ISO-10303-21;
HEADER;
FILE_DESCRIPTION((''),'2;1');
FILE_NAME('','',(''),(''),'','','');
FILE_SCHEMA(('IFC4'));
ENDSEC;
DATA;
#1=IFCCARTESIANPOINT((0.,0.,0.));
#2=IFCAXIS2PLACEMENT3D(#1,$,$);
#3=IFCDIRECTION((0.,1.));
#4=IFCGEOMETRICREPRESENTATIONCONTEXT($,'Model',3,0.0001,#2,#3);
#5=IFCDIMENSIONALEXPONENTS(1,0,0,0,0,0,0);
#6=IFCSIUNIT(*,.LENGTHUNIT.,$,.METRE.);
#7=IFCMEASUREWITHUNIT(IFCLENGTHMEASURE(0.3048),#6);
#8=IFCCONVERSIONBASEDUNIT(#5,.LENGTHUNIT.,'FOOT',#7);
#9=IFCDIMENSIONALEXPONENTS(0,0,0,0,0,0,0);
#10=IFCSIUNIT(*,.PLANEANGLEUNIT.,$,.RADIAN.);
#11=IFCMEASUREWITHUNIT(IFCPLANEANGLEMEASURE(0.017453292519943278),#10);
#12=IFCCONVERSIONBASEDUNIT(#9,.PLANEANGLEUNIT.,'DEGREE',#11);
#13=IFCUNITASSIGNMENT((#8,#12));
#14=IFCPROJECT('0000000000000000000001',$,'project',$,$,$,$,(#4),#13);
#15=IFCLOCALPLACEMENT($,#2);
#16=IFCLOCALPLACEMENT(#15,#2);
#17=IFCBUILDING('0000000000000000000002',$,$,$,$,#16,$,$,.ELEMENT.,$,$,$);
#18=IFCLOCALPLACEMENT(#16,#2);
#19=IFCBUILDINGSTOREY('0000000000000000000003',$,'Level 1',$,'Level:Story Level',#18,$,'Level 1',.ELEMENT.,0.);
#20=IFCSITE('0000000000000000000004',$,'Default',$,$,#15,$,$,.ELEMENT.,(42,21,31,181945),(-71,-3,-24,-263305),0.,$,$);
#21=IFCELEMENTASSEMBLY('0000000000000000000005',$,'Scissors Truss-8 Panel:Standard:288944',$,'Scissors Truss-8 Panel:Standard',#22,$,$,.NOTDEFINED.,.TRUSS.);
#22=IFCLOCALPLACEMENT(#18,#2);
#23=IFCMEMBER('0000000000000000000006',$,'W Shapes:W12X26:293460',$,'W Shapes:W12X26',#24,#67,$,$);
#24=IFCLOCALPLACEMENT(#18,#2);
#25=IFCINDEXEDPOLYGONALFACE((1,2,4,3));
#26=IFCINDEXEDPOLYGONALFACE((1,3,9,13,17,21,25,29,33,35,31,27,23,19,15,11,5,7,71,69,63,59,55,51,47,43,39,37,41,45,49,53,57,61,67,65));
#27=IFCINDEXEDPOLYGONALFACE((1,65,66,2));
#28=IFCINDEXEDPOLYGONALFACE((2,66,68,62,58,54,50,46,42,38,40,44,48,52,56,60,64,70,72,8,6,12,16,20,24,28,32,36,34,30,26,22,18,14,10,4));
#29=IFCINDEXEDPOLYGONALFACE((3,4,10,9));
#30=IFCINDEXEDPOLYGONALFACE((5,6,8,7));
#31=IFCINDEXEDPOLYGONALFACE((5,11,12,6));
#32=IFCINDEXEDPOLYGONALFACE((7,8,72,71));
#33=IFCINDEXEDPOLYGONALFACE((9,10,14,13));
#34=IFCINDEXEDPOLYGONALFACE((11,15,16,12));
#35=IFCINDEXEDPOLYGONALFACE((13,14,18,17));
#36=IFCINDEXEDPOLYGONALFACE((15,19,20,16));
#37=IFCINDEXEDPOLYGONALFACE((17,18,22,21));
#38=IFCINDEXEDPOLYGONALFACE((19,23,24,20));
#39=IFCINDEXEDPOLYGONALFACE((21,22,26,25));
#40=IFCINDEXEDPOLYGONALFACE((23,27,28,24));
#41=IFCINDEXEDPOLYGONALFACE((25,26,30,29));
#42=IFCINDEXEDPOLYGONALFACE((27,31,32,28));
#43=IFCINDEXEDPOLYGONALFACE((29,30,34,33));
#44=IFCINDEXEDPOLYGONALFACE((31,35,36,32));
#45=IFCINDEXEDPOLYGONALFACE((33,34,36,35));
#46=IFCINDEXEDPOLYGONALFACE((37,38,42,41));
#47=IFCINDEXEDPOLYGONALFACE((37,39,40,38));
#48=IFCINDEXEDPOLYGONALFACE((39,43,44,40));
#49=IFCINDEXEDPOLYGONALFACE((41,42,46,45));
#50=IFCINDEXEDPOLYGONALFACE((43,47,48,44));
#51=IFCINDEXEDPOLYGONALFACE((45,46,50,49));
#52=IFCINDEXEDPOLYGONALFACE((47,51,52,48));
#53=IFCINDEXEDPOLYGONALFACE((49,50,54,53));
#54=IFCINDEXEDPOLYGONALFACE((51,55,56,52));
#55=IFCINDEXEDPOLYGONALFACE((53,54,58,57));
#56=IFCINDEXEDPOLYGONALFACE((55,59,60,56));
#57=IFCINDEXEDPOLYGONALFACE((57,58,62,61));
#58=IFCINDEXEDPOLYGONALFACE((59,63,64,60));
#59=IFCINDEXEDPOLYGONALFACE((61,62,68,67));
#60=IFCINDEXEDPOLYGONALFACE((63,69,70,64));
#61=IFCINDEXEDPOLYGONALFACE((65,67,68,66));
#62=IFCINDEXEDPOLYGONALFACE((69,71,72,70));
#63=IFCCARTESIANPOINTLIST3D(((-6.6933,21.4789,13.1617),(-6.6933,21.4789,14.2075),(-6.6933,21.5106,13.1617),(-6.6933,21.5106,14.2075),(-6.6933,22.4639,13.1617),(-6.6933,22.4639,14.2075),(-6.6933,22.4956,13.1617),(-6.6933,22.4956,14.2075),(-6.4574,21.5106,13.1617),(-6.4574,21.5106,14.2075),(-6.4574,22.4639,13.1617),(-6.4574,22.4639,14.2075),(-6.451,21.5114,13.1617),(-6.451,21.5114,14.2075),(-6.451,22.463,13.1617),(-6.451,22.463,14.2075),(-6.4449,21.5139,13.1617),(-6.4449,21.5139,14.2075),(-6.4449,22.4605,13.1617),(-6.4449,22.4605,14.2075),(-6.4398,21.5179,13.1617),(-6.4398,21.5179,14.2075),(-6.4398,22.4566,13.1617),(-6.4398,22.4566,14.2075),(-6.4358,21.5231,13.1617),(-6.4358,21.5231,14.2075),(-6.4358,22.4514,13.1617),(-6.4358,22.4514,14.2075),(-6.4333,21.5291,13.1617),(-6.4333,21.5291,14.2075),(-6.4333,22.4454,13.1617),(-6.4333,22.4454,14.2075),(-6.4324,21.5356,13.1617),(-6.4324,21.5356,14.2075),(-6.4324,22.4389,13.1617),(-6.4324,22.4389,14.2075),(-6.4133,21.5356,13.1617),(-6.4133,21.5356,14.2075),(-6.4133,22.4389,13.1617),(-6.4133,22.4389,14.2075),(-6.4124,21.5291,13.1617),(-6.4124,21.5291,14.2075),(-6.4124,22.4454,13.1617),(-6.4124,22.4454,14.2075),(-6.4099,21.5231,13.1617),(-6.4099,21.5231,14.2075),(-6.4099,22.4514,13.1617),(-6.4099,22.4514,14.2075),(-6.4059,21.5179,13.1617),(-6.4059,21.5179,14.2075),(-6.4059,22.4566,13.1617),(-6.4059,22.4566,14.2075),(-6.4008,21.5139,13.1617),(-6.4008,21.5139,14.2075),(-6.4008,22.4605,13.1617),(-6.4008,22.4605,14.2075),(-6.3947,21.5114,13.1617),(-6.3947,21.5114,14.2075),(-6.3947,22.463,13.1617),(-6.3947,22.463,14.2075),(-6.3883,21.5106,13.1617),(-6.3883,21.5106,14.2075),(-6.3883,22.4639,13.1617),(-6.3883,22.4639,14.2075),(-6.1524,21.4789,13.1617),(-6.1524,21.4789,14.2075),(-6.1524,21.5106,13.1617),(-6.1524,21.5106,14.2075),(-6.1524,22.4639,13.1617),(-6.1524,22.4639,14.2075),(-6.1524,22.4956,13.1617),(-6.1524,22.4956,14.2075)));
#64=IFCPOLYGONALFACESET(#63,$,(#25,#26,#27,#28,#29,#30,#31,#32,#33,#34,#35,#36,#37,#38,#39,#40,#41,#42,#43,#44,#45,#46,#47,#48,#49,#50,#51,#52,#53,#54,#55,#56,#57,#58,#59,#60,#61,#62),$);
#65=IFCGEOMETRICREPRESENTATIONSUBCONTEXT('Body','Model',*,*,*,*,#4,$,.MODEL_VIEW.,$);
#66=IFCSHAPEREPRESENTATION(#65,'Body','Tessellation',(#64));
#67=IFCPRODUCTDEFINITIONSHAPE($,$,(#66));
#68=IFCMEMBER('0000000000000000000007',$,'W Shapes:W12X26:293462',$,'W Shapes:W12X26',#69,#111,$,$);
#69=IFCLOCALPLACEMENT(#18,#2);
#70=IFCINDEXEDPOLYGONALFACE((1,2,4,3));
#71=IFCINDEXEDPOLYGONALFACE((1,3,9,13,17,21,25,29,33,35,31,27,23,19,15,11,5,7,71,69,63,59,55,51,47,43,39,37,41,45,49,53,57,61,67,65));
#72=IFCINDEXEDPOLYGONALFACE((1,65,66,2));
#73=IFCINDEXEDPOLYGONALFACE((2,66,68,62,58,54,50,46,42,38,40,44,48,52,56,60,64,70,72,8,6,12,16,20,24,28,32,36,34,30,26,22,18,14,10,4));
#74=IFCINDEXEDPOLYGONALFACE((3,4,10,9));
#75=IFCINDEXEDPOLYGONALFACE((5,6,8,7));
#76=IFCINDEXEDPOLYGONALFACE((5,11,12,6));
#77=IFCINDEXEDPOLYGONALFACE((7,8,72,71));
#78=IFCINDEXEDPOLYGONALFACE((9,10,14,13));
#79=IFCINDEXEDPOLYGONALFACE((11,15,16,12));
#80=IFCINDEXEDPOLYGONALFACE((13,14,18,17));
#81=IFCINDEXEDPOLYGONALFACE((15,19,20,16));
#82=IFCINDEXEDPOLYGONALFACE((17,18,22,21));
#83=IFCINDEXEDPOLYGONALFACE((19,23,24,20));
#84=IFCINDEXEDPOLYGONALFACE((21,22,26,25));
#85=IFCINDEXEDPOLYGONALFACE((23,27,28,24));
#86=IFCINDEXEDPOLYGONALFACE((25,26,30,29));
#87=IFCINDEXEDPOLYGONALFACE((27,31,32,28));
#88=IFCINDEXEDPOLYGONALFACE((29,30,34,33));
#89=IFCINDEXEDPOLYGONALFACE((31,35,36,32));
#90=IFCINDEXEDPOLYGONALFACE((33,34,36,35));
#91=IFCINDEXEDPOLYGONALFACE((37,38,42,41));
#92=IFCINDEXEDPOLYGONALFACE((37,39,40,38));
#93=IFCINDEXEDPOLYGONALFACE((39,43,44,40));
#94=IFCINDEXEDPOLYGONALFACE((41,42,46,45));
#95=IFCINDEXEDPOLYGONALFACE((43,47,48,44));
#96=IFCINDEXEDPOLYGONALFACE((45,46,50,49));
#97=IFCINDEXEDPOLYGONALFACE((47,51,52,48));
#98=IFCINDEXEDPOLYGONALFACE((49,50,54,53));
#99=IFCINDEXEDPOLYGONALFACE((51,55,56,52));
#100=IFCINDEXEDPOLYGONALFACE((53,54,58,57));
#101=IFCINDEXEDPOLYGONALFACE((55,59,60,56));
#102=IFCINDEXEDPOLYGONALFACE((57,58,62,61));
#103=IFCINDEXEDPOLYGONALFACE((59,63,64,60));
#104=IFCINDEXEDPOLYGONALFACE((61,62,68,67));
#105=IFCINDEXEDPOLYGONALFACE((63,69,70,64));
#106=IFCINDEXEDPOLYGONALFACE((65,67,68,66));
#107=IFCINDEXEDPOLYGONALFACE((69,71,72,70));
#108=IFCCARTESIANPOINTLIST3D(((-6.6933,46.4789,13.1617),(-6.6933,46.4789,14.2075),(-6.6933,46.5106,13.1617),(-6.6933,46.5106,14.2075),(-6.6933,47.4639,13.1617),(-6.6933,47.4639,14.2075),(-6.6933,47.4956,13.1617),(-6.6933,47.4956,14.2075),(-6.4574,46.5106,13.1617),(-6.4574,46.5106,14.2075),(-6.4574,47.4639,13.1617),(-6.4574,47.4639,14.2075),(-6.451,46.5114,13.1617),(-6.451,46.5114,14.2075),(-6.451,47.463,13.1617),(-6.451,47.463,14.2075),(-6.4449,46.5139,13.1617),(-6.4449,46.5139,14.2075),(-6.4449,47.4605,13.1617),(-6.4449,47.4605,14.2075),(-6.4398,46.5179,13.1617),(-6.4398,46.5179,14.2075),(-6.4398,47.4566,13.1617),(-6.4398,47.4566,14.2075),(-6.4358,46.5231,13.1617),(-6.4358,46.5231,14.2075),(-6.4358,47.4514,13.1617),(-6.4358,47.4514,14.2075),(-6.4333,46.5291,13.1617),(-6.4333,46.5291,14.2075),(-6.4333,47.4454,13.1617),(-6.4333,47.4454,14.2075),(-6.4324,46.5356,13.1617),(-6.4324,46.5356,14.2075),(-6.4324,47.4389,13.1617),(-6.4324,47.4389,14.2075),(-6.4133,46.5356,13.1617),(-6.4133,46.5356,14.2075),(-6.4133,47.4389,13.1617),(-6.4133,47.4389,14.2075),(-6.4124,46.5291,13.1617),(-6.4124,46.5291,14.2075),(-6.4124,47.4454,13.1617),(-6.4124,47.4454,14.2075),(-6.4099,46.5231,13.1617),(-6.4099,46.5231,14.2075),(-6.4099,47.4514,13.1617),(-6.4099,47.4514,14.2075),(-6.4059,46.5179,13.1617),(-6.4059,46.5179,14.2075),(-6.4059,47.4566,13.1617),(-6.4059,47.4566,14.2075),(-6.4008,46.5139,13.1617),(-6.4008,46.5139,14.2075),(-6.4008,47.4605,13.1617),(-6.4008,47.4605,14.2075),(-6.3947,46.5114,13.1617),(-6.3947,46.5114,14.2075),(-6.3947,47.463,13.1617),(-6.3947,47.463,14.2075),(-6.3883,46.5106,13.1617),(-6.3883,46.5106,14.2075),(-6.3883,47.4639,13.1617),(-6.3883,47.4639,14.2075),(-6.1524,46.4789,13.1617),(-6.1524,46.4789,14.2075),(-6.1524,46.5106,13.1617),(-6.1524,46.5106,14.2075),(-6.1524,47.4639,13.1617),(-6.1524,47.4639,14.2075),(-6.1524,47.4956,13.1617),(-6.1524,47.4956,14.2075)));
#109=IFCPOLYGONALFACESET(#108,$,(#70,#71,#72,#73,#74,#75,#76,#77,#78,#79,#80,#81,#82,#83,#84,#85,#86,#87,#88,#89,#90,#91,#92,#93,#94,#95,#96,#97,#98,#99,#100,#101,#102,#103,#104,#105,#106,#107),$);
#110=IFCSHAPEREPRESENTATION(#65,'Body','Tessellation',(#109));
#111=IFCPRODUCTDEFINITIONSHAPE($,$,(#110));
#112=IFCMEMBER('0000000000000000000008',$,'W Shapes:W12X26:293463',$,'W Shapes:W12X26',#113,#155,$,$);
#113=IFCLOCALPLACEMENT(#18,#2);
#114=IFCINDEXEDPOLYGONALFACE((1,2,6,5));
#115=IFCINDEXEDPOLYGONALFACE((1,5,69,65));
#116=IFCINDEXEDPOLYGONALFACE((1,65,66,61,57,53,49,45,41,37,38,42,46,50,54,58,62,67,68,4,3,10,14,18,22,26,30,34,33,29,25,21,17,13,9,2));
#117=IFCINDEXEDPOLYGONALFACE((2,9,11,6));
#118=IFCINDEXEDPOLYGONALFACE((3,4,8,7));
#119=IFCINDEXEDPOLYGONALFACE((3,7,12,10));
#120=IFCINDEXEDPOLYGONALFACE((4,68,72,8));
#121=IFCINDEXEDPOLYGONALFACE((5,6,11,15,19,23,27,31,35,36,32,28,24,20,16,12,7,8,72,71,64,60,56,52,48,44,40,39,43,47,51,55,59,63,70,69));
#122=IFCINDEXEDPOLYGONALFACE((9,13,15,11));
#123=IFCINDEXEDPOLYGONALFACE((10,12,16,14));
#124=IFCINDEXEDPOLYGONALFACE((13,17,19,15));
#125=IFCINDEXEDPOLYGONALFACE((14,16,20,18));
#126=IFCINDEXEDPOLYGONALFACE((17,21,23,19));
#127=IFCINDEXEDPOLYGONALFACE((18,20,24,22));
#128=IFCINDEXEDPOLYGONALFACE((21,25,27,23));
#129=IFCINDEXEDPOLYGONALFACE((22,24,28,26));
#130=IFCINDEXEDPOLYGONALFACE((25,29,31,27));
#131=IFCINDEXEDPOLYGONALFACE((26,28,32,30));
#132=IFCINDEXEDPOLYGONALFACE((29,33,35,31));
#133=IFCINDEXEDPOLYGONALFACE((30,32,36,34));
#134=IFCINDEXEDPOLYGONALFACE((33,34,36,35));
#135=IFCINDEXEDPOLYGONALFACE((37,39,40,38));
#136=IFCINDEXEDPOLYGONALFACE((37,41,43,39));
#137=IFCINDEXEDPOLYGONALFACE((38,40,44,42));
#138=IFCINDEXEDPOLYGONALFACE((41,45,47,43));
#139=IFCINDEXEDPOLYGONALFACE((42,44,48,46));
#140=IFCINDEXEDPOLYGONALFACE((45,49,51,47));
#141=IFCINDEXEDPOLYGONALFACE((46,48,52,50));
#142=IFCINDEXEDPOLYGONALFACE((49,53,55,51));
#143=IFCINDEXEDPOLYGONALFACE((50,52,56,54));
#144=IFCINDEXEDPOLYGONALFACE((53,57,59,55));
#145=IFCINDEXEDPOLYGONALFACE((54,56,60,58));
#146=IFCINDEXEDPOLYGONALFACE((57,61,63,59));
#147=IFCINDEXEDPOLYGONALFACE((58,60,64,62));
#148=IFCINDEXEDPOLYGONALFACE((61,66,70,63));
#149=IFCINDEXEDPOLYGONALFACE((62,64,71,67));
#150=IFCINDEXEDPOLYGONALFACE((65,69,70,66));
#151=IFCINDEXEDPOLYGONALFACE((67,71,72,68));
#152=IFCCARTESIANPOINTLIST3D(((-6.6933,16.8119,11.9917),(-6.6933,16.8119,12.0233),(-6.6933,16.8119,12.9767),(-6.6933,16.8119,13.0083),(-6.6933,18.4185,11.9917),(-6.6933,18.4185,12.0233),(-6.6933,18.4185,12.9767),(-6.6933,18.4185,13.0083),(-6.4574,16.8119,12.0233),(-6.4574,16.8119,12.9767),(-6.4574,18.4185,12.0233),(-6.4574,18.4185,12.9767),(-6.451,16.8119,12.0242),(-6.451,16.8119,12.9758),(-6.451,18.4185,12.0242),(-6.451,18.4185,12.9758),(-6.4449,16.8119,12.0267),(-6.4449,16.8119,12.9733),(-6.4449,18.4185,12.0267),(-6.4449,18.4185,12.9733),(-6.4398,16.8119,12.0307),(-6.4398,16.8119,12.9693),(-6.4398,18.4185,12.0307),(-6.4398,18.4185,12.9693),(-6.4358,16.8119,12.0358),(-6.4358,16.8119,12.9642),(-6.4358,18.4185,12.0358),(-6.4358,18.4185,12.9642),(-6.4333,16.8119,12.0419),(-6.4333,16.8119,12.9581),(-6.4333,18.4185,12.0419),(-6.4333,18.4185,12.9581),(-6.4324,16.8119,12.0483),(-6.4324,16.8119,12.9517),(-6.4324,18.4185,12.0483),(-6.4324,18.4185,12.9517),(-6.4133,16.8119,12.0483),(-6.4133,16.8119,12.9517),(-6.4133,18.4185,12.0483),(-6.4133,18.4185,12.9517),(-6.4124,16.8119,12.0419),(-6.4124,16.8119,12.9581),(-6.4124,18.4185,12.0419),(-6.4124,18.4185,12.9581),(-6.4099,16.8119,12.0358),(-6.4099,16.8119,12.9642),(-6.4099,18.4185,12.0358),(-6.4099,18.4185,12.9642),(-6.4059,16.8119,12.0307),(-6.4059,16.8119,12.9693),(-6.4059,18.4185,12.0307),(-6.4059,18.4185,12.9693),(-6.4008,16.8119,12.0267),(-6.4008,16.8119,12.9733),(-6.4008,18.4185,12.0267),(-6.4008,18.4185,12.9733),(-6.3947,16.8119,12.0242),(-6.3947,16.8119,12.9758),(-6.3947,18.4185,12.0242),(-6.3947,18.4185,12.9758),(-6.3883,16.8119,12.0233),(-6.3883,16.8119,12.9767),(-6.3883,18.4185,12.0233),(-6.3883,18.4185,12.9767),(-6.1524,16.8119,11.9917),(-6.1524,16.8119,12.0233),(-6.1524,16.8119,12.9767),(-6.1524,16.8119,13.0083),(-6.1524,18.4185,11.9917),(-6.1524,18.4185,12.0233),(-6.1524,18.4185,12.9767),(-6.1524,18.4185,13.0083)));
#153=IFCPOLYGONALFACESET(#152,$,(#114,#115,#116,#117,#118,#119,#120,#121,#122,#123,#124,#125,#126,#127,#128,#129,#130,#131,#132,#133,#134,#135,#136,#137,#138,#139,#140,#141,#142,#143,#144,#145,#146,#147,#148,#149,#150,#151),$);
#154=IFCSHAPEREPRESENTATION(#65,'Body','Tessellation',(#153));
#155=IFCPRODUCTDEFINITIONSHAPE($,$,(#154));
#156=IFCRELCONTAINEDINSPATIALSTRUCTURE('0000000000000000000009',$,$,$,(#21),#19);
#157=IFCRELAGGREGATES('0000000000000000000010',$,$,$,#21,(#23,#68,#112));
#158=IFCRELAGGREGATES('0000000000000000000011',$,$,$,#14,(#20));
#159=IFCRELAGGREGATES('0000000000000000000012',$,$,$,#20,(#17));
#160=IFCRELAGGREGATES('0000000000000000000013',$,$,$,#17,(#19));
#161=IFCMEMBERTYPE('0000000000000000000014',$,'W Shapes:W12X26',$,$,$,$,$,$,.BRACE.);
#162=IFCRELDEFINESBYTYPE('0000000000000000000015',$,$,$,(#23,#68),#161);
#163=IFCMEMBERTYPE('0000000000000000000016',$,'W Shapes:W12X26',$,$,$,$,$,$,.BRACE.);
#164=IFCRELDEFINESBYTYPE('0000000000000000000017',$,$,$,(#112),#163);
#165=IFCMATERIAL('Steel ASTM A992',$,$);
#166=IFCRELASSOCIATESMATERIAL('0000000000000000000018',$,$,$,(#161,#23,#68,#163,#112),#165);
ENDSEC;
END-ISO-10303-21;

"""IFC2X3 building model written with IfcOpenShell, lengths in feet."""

from ifc_helpers import new_model, entity, si_unit, converted_unit, direction, frame, frame_2d, origin, place, context, subcontext, project, spatial, polyline, circle_curve, parameter, trimmed, segment, composite_curve, outline, extrude, source, transform, mapped, material, type_object, type_shapes, element, aggregate, save


model = new_model("IFC2X3")

# Units and contexts
model_context = context("Model", 3, precision=0.0001, world=origin(), true_north=direction((0.0, 1.0)))
body_context = subcontext(model_context, "Body", "Model", "MODEL_VIEW")
ifc_project = project(units=[converted_unit("LENGTHUNIT", "FOOT", entity("IfcLengthMeasure", 0.3048), si_unit("LENGTHUNIT", "METRE"), dimensions=[1, 0, 0, 0, 0, 0, 0]), converted_unit("PLANEANGLEUNIT", "DEGREE", entity("IfcPlaneAngleMeasure", 0.017453292519943278), si_unit("PLANEANGLEUNIT", "RADIAN"), dimensions=[0, 0, 0, 0, 0, 0, 0])], contexts=[model_context])

# Site, building, storey
site_placement = place(None, origin())
site = spatial("IfcSite", under=ifc_project, at=site_placement, Name="Default", CompositionType="ELEMENT", RefLatitude=(42, 21, 31, 181945), RefLongitude=(-71, -3, -24, -263305), RefElevation=0.0)
building_placement = place(site_placement, origin())
building = spatial("IfcBuilding", under=site, at=building_placement, CompositionType="ELEMENT")
storey_placement = place(building_placement, origin())
storey = spatial("IfcBuildingStorey", under=building, at=storey_placement, Name="Level 1", ObjectType="Level:Story Level", LongName="Level 1", CompositionType="ELEMENT", Elevation=0.0)

# Element assembly, members
assembly_placement = place(storey_placement, origin())
assembly = element("IfcElementAssembly", 1, at=assembly_placement, inside=storey, Name="Scissors Truss-8 Panel:Standard:288944", ObjectType="Scissors Truss-8 Panel:Standard", AssemblyPlace="NOTDEFINED", PredefinedType="TRUSS")
ifc_material = material(Name="Steel ASTM A992")
member_type_1 = type_object("IfcMemberType", Name="W Shapes:W12X26", PredefinedType="BRACE", material=ifc_material)
shared_shape_1 = source(origin(), body_context, "Body", "SweptSolid", [
    extrude(outline(composite_curve([segment(polyline([(-0.2704, -0.4767), (-0.2704, -0.5083)]), True, "CONTINUOUS"), segment(polyline([(-0.2704, -0.5083), (0.2704, -0.5083)]), True, "CONTINUOUS"), segment(polyline([(0.2704, -0.5083), (0.2704, -0.4767)]), True, "CONTINUOUS"), segment(polyline([(0.2704, -0.4767), (0.0346, -0.4767)]), True, "CONTINUOUS"), segment(trimmed(circle_curve(frame_2d((0.0346, -0.4517), x_axis=(0.0, -1.0)), 0.025), [parameter(270.0)], [parameter(360.0)], True, "PARAMETER"), False, "CONTINUOUS"), segment(polyline([(0.0096, -0.4517), (0.0096, 0.4517)]), True, "CONTINUOUS"), segment(trimmed(circle_curve(frame_2d((0.0346, 0.4517), x_axis=(-1.0, 0.0)), 0.025), [parameter(270.0)], [parameter(360.0)], True, "PARAMETER"), False, "CONTINUOUS"), segment(polyline([(0.0346, 0.4767), (0.2704, 0.4767)]), True, "CONTINUOUS"), segment(polyline([(0.2704, 0.4767), (0.2704, 0.5083)]), True, "CONTINUOUS"), segment(polyline([(0.2704, 0.5083), (-0.2704, 0.5083)]), True, "CONTINUOUS"), segment(polyline([(-0.2704, 0.5083), (-0.2704, 0.4767)]), True, "CONTINUOUS"), segment(polyline([(-0.2704, 0.4767), (-0.0346, 0.4767)]), True, "CONTINUOUS"), segment(trimmed(circle_curve(frame_2d((-0.0346, 0.4517), x_axis=(0.0, 1.0)), 0.025), [parameter(270.0)], [parameter(0.0)], True, "PARAMETER"), False, "CONTINUOUS"), segment(polyline([(-0.0096, 0.4517), (-0.0096, -0.4517)]), True, "CONTINUOUS"), segment(trimmed(circle_curve(frame_2d((-0.0346, -0.4517), x_axis=(1.0, 0.0)), 0.025), [parameter(270.0)], [parameter(0.0)], True, "PARAMETER"), False, "CONTINUOUS"), segment(polyline([(-0.0346, -0.4767), (-0.2704, -0.4767)]), True, "CONTINUOUS")], self_intersect=False)), frame((-0.5883, 0.0, 0.0), z_axis=(-1.0, 0.0, 0.0), x_axis=(0.0, -1.0, 0.0)), (0.0, 0.0, -1.0), 1.0458),
])
type_shapes(member_type_1, [shared_shape_1])
member_1_placement = place(assembly_placement, frame((-6.4228, 21.9872, 13.75), z_axis=(0.0, 1.0, 0.0), x_axis=(0.0, 0.0, 1.0)))
member_1 = element("IfcMember", 2, at=member_1_placement, type_object=member_type_1, material=ifc_material, Name="W Shapes:W12X26:293460", ObjectType="W Shapes:W12X26", context=body_context, shape_type="MappedRepresentation", body=[
    mapped(shared_shape_1, transform((0.0, 0.0, 0.0), scale=1.0)),
])
member_2_placement = place(assembly_placement, frame((-6.4228, 46.9872, 13.75), z_axis=(0.0, 1.0, 0.0), x_axis=(0.0, 0.0, 1.0)))
member_2 = element("IfcMember", 3, at=member_2_placement, type_object=member_type_1, material=ifc_material, Name="W Shapes:W12X26:293462", ObjectType="W Shapes:W12X26", context=body_context, shape_type="MappedRepresentation", body=[
    mapped(shared_shape_1, transform((0.0, 0.0, 0.0), scale=1.0)),
])
member_type_2 = type_object("IfcMemberType", Name="W Shapes:W12X26", PredefinedType="BRACE", material=ifc_material)
shared_shape_2 = source(origin(), body_context, "Body", "SweptSolid", [
    extrude(outline(composite_curve([segment(polyline([(0.4767, -0.2704), (0.5083, -0.2704)]), True, "CONTINUOUS"), segment(polyline([(0.5083, -0.2704), (0.5083, 0.2704)]), True, "CONTINUOUS"), segment(polyline([(0.5083, 0.2704), (0.4767, 0.2704)]), True, "CONTINUOUS"), segment(polyline([(0.4767, 0.2704), (0.4767, 0.0346)]), True, "CONTINUOUS"), segment(trimmed(circle_curve(frame_2d((0.4517, 0.0346), x_axis=(0.0, 1.0)), 0.025), [parameter(180.0)], [parameter(270.0)], True, "PARAMETER"), False, "CONTINUOUS"), segment(polyline([(0.4517, 0.0096), (-0.4517, 0.0096)]), True, "CONTINUOUS"), segment(trimmed(circle_curve(frame_2d((-0.4517, 0.0346), x_axis=(0.0, 1.0)), 0.025), [parameter(90.0)], [parameter(180.0)], True, "PARAMETER"), False, "CONTINUOUS"), segment(polyline([(-0.4767, 0.0346), (-0.4767, 0.2704)]), True, "CONTINUOUS"), segment(polyline([(-0.4767, 0.2704), (-0.5083, 0.2704)]), True, "CONTINUOUS"), segment(polyline([(-0.5083, 0.2704), (-0.5083, -0.2704)]), True, "CONTINUOUS"), segment(polyline([(-0.5083, -0.2704), (-0.4767, -0.2704)]), True, "CONTINUOUS"), segment(polyline([(-0.4767, -0.2704), (-0.4767, -0.0346)]), True, "CONTINUOUS"), segment(trimmed(circle_curve(frame_2d((-0.4517, -0.0346), x_axis=(0.0, 1.0)), 0.025), [parameter(360.0)], [parameter(90.0)], True, "PARAMETER"), False, "CONTINUOUS"), segment(polyline([(-0.4517, -0.0096), (0.4517, -0.0096)]), True, "CONTINUOUS"), segment(trimmed(circle_curve(frame_2d((0.4517, -0.0346), x_axis=(0.0, 1.0)), 0.025), [parameter(270.0)], [parameter(360.0)], True, "PARAMETER"), False, "CONTINUOUS"), segment(polyline([(0.4767, -0.0346), (0.4767, -0.2704)]), True, "CONTINUOUS")], self_intersect=False)), frame((-2.0503, 0.0, 0.0), z_axis=(1.0, 0.0, 0.0), x_axis=(0.0, 0.0, -1.0)), (0.0, 0.0, 1.0), 1.6066),
])
type_shapes(member_type_2, [shared_shape_2])
member_3_placement = place(assembly_placement, frame((-6.4228, 18.8622, 12.5), z_axis=(0.0, 0.0, -1.0), x_axis=(0.0, 1.0, 0.0)))
member_3 = element("IfcMember", 4, at=member_3_placement, type_object=member_type_2, material=ifc_material, Name="W Shapes:W12X26:293463", ObjectType="W Shapes:W12X26", context=body_context, shape_type="MappedRepresentation", body=[
    mapped(shared_shape_2, transform((0.0, 0.0, 0.0), scale=1.0)),
])
aggregate(assembly, [member_1, member_2, member_3])

save(model, "model.ifc")
